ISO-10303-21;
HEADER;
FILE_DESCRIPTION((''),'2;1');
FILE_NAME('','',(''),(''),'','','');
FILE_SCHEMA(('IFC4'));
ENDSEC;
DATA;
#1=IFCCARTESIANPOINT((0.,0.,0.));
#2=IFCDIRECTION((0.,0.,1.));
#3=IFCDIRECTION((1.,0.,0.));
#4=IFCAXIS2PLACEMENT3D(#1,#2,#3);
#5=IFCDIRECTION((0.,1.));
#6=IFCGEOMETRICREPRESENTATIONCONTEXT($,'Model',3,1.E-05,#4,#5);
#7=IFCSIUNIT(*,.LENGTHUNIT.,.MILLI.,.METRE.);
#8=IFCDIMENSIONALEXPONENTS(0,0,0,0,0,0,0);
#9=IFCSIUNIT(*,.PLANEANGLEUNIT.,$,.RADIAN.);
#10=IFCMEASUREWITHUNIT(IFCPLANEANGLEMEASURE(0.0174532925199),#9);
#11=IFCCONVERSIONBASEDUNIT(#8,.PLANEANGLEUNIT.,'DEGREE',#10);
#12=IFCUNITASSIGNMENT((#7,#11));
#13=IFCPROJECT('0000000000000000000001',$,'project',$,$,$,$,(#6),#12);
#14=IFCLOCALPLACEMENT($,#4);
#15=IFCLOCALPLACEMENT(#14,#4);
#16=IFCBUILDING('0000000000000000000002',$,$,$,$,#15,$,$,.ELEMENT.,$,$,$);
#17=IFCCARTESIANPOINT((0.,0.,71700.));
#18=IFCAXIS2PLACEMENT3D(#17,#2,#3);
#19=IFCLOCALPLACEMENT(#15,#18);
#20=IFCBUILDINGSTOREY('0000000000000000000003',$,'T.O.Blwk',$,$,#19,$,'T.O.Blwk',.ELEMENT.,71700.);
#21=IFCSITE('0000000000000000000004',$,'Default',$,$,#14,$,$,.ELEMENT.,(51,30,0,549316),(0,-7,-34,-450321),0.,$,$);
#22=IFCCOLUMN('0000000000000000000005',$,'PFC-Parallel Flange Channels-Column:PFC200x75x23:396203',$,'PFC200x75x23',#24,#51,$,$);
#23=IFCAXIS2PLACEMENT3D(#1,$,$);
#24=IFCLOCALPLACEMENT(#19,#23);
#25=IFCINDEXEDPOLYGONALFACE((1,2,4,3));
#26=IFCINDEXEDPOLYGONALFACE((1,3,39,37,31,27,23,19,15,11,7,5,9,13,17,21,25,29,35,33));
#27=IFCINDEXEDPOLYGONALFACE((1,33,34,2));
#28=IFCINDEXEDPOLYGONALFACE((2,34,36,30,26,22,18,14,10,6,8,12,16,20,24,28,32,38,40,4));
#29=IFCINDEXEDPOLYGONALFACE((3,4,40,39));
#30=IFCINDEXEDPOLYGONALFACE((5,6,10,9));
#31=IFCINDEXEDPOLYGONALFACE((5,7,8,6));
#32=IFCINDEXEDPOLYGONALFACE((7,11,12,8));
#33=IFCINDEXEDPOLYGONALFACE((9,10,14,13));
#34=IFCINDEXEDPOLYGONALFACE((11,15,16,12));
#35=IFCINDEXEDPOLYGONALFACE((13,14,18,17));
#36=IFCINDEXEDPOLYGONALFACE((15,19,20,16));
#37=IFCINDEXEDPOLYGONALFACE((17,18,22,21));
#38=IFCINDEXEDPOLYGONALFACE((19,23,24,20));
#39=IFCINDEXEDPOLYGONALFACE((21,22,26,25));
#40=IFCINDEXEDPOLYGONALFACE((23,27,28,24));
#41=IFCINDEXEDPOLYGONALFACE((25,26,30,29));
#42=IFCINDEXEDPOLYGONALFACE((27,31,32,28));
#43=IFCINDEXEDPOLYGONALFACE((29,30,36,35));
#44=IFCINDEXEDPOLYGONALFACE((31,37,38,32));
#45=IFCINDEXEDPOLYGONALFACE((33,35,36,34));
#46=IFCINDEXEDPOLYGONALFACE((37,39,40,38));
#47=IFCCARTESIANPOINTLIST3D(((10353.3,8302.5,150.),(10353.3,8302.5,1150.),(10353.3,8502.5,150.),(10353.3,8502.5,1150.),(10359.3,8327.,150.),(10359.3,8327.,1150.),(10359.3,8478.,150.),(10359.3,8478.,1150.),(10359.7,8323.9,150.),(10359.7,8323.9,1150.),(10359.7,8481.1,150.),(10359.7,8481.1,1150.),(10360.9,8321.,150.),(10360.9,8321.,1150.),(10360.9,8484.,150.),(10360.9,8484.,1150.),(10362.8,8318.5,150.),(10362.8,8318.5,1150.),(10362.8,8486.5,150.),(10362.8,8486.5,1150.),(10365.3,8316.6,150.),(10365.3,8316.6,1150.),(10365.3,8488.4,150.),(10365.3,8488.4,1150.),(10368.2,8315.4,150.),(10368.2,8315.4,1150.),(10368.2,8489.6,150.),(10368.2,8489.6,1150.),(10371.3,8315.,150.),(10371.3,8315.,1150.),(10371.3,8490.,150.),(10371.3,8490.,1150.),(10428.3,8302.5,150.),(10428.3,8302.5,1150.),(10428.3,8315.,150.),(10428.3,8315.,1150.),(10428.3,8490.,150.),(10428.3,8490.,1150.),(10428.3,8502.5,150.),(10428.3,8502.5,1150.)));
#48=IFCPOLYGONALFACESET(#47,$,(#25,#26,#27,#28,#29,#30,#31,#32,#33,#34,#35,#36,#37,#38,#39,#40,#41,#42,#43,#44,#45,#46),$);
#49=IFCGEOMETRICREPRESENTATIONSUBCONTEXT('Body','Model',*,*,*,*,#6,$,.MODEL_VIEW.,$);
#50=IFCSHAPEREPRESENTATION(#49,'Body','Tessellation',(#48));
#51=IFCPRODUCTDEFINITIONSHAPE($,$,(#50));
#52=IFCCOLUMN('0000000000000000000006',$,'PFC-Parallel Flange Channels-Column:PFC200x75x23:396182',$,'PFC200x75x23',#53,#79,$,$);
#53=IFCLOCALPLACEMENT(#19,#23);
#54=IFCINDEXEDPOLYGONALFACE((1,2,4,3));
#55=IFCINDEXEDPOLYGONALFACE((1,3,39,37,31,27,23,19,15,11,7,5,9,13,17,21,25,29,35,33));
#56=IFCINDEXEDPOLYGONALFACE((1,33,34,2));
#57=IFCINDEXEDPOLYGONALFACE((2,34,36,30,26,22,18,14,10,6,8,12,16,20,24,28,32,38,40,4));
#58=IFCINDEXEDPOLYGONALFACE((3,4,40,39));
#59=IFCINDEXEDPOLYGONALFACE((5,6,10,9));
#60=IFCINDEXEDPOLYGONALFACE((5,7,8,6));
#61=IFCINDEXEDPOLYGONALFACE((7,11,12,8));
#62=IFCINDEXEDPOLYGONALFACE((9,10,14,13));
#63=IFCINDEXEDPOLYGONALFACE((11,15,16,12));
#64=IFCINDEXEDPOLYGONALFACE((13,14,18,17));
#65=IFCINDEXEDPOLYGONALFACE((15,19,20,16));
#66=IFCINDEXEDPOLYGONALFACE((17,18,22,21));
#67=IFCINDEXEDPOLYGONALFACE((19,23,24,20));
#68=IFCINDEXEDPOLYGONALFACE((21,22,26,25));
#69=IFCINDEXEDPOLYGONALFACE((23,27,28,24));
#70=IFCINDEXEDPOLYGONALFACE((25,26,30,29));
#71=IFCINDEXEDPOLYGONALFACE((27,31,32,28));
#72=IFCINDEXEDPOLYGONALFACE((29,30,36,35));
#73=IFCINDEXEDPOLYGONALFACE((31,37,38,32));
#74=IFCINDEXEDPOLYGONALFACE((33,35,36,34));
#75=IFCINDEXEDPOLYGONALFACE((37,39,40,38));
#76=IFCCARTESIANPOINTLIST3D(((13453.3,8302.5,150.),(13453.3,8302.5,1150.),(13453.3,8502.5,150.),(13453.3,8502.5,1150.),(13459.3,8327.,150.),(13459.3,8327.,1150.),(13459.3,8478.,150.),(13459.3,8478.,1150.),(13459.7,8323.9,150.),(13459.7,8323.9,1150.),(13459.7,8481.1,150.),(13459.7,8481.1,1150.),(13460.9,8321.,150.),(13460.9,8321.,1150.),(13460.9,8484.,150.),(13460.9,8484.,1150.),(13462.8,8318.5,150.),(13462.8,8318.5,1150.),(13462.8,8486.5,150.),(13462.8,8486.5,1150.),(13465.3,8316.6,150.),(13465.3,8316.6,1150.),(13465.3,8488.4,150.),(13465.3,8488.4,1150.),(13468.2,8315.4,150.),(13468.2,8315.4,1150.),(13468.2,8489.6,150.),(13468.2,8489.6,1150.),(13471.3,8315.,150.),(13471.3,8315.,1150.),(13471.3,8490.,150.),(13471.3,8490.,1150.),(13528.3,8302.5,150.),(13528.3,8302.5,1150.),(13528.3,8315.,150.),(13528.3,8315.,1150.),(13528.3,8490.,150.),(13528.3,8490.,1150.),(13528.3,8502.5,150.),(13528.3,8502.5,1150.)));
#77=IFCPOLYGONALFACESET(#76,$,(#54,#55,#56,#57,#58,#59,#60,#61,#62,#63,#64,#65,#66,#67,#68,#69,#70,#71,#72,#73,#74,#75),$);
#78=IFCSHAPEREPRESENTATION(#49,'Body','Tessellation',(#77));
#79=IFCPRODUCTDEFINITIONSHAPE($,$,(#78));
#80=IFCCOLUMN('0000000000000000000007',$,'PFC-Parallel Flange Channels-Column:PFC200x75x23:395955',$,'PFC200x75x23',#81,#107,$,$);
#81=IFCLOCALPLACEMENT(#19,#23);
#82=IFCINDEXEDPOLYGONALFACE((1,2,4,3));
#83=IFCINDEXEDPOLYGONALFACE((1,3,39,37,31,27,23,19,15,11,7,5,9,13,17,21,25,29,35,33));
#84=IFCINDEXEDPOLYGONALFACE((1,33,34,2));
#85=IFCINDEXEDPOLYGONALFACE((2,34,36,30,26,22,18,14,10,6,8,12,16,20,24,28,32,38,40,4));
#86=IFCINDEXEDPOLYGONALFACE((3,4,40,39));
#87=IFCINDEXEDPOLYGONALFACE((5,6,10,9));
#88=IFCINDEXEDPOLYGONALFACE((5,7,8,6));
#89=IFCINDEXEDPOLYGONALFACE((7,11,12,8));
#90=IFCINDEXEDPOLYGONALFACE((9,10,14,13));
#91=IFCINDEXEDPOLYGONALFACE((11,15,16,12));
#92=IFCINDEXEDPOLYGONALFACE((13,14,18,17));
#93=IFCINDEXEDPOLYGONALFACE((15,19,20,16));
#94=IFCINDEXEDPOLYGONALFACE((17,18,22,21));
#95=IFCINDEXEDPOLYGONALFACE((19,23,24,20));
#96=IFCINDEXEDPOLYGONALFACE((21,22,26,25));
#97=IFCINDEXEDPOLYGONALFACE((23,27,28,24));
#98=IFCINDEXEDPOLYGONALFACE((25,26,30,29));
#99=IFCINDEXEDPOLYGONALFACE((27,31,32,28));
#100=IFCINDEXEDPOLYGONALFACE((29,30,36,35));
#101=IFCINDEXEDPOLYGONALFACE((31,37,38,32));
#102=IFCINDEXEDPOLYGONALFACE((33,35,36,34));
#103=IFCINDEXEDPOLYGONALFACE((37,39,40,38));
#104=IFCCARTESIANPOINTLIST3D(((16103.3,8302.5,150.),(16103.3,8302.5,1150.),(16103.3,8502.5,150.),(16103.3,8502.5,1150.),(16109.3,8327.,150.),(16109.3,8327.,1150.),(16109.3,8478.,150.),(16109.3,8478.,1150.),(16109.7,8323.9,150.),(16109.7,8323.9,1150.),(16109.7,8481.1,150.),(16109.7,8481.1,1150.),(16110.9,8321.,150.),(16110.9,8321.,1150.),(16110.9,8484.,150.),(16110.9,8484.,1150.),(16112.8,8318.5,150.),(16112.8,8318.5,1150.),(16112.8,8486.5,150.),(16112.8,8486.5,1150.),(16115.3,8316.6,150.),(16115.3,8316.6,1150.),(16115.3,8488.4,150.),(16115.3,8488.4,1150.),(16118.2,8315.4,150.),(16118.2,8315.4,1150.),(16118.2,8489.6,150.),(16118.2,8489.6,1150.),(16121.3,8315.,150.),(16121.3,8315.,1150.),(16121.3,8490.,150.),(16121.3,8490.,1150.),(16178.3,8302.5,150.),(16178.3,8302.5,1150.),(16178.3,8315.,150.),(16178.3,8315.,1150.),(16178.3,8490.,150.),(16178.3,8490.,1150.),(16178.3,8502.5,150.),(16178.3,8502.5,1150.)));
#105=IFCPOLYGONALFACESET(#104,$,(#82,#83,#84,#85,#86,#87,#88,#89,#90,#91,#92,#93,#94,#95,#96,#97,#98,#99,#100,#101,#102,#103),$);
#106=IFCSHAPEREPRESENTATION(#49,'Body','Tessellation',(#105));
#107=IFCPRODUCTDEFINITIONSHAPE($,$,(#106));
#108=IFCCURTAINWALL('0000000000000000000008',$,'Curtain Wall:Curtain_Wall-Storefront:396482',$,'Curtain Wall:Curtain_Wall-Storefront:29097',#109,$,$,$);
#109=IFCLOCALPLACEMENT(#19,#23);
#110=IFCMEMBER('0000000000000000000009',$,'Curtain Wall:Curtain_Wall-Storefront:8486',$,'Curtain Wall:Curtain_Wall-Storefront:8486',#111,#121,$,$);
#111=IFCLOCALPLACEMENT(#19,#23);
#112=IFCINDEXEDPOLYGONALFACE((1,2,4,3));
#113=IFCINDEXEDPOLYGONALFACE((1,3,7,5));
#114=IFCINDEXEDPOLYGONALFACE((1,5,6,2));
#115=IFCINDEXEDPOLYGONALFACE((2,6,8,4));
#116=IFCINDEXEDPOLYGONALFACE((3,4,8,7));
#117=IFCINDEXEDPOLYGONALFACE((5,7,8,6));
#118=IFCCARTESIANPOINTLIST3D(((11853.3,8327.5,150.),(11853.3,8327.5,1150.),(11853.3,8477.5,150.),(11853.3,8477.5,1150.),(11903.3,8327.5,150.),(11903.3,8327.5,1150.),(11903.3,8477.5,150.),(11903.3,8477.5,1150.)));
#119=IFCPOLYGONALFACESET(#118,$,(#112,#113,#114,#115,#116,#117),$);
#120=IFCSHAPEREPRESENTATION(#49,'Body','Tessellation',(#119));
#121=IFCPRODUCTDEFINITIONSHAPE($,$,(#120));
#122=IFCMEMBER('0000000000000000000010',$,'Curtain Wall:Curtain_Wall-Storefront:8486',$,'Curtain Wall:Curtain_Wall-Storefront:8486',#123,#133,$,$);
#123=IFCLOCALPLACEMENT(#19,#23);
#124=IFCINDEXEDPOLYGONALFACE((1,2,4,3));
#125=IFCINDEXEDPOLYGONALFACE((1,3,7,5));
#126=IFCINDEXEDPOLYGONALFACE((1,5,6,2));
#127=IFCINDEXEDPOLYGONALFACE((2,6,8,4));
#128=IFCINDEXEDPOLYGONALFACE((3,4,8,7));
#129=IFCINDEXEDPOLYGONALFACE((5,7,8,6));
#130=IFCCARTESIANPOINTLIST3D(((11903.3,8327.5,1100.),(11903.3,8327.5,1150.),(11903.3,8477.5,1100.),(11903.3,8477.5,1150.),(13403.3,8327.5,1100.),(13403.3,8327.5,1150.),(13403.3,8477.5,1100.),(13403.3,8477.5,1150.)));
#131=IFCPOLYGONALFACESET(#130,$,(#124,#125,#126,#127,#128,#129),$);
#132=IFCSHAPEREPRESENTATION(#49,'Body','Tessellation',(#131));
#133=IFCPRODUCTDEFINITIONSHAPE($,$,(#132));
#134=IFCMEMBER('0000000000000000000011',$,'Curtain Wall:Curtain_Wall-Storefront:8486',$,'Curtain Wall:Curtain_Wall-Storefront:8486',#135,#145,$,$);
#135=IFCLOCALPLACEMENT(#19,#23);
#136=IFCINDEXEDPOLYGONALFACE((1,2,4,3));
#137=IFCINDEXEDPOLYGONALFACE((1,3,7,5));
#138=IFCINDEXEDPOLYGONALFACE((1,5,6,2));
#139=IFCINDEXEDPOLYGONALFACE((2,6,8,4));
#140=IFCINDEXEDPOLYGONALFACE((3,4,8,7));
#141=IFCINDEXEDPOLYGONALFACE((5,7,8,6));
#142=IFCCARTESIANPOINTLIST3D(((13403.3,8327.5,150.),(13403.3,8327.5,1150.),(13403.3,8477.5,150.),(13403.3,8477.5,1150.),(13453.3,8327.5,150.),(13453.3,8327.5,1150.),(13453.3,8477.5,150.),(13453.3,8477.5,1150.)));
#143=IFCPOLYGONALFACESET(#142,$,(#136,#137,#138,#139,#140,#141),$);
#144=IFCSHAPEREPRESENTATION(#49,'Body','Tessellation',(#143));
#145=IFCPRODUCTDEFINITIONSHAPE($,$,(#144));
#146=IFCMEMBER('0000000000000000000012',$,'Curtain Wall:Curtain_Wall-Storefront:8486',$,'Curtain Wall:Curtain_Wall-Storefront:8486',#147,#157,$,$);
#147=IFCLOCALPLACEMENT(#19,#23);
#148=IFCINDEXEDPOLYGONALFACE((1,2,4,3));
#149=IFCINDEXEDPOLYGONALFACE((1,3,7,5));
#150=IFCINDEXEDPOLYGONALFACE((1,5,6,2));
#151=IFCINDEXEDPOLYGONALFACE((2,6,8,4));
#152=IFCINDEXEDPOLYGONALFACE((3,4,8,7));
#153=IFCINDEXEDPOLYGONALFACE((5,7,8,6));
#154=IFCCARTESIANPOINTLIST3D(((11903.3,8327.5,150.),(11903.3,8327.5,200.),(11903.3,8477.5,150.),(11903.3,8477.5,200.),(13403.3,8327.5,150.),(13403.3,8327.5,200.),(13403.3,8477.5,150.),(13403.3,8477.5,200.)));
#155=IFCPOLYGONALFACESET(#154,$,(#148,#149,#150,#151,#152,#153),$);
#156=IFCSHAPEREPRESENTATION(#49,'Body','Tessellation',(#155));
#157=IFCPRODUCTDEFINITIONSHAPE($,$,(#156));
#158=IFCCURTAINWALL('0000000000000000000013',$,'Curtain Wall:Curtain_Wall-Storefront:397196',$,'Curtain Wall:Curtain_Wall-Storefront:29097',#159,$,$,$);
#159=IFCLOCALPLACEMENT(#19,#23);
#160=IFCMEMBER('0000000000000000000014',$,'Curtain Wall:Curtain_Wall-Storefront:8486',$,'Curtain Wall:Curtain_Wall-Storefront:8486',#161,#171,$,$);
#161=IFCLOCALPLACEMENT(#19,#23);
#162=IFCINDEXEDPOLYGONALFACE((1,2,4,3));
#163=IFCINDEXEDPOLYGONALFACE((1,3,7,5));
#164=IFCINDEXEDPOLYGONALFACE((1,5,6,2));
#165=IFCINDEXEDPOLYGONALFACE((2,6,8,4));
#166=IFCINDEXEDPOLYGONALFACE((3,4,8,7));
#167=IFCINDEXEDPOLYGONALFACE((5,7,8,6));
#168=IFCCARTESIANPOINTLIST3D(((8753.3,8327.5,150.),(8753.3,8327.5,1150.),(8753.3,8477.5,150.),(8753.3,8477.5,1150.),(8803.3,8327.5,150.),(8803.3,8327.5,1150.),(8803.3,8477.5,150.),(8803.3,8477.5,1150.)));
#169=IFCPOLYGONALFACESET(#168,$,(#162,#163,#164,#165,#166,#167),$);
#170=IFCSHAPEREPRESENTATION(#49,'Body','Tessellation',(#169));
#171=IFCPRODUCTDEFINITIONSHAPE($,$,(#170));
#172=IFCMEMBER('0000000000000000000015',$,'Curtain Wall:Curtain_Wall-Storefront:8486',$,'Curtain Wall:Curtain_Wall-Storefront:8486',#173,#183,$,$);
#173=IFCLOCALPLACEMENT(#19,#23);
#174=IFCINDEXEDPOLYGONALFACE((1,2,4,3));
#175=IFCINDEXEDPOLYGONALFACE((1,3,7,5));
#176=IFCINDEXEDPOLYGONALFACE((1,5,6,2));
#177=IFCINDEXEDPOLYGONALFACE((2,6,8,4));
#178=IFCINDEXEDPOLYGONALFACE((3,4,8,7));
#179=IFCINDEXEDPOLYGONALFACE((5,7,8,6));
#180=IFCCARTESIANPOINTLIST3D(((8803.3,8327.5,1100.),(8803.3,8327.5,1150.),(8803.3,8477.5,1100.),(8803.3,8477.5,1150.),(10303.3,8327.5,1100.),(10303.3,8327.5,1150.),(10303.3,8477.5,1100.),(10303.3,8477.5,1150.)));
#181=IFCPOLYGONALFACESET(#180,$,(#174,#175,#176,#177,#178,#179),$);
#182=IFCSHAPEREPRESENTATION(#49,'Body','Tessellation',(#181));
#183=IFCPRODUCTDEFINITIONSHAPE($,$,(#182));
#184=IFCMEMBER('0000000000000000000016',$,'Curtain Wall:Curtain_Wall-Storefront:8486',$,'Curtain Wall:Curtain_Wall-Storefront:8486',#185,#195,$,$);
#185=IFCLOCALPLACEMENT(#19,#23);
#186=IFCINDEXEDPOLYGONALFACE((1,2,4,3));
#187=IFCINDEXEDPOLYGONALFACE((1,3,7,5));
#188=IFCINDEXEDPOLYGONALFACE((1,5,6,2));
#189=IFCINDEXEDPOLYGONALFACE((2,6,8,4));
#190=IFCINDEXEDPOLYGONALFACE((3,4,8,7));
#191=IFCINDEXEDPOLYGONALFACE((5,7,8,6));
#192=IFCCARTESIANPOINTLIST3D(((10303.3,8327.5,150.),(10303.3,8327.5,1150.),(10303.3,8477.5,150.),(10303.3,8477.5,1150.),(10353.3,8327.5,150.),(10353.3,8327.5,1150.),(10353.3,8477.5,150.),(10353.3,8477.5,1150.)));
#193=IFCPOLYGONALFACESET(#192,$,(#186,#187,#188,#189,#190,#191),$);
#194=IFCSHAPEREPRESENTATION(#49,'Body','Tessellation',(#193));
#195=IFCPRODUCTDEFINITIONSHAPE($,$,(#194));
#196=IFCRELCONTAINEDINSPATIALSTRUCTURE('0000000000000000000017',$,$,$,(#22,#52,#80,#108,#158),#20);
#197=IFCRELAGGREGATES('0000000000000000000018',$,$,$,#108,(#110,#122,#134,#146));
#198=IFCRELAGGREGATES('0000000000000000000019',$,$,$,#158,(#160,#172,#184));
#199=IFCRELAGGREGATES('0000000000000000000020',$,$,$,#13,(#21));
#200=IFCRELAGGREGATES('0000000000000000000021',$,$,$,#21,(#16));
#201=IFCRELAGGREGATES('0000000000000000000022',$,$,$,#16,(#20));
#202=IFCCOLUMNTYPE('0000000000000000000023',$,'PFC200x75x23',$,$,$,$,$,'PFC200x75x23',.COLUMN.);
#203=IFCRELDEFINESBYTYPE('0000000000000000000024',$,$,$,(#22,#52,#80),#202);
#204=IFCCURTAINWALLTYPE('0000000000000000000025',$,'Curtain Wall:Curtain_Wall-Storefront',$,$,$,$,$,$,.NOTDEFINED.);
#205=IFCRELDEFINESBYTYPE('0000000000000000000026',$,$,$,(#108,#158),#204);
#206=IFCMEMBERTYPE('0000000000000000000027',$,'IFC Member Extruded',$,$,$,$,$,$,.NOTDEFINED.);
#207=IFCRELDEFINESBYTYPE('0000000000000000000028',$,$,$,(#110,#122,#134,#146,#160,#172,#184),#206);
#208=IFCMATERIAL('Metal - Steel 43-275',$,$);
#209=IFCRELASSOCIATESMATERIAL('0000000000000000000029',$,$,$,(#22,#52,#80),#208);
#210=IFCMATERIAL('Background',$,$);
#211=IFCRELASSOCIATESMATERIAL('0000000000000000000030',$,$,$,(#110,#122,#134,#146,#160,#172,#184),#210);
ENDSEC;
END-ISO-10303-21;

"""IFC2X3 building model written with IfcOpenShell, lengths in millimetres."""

from ifc_helpers import new_model, entity, si_unit, converted_unit, point, direction, frame, frame_2d, origin_with_axes, origin_2d_with_axis, place, context, subcontext, project, spatial, polyline, circle_curve, parameter, trimmed, segment, composite_curve, rectangle, outline, extrude, material, type_object, element, aggregate, save


model = new_model("IFC2X3")

# Units and contexts
model_context = context("Model", 3, precision=1e-05, world=origin_with_axes(), true_north=direction((0.0, 1.0)))
body_context = subcontext(model_context, "Body", "Model", "MODEL_VIEW")
ifc_project = project(units=[si_unit("LENGTHUNIT", "METRE", prefix="MILLI"), converted_unit("PLANEANGLEUNIT", "DEGREE", entity("IfcPlaneAngleMeasure", 0.0174532925199), si_unit("PLANEANGLEUNIT", "RADIAN"), dimensions=[0, 0, 0, 0, 0, 0, 0])], contexts=[model_context])

# Site, building, storey
site_placement = place(None, origin_with_axes())
site = spatial("IfcSite", under=ifc_project, at=site_placement, Name="Default", CompositionType="ELEMENT", RefLatitude=(51, 30, 0, 549316), RefLongitude=(0, -7, -34, -450321), RefElevation=0.0)
building_placement = place(site_placement, origin_with_axes())
building = spatial("IfcBuilding", under=site, at=building_placement, CompositionType="ELEMENT")
storey_placement = place(building_placement, frame((0.0, 0.0, 71700.0), z_axis=(0.0, 0.0, 1.0), x_axis=(1.0, 0.0, 0.0)))
storey = spatial("IfcBuildingStorey", under=building, at=storey_placement, Name="T.O.Blwk", LongName="T.O.Blwk", CompositionType="ELEMENT", Elevation=71700.0)

# Columns
ifc_material_1 = material(Name="Metal - Steel 43-275")
column_type_1 = type_object("IfcColumnType", Name="PFC200x75x23", ElementType="PFC200x75x23", PredefinedType="COLUMN")
for number, where, z_axis, x_axis, name in (
    (1, (10388.1, 8402.5, 150.0), (0.0, 0.0, 1.0), (0.0, -1.0, 0.0), "PFC-Parallel Flange Channels-Column:PFC200x75x23:396203"),
    (2, (13488.1, 8402.5, 150.0), (0.0, 0.0, 1.0), (0.0, -1.0, 0.0), "PFC-Parallel Flange Channels-Column:PFC200x75x23:396182"),
    (3, (16138.1, 8402.5, 150.0), (0.0, 0.0, 1.0), (0.0, -1.0, 0.0), "PFC-Parallel Flange Channels-Column:PFC200x75x23:395955"),
):
    element("IfcColumn", number, at=place(storey_placement, frame(where, z_axis=z_axis, x_axis=x_axis)), inside=storey, type_object=column_type_1, material=ifc_material_1, Name=name, ObjectType="PFC200x75x23", context=body_context, shape_type="SweptSolid", body=[
        extrude(outline(composite_curve([segment(polyline([(-100.0, -34.8), (100.0, -34.8), (100.0, 40.2), (87.5, 40.2), (87.5, -16.8)]), True, "CONTINUOUS"), segment(trimmed(circle_curve(frame_2d((75.5, -16.8), x_axis=(0.0, -1.0)), 12.0), [point((87.5, -16.8)), parameter(90.0)], [point((75.5, -28.8)), parameter(0.0)], False, "CARTESIAN"), True, "CONTINUOUS"), segment(polyline([(75.5, -28.8), (-75.5, -28.8)]), True, "CONTINUOUS"), segment(trimmed(circle_curve(frame_2d((-75.5, -16.8), x_axis=(-1.0, 0.0)), 12.0), [point((-75.5, -28.8)), parameter(90.0)], [point((-87.5, -16.8)), parameter(0.0)], False, "CARTESIAN"), True, "CONTINUOUS"), segment(polyline([(-87.5, -16.8), (-87.5, 40.2), (-100.0, 40.2), (-100.0, -34.8)]), True, "CONTINUOUS")], self_intersect=False)), origin_with_axes(), (0.0, 0.0, 1.0), 1000.0),
    ])

# Curtain walls, members
curtain_wall_type = type_object("IfcCurtainWallType", Name="Curtain Wall:Curtain_Wall-Storefront", PredefinedType="NOTDEFINED")
curtain_wall_1_placement = place(storey_placement, frame((0.0, 0.0, -71700.0), z_axis=(0.0, 0.0, 1.0), x_axis=(1.0, 0.0, 0.0)))
curtain_wall_1 = element("IfcCurtainWall", 4, at=curtain_wall_1_placement, inside=storey, type_object=curtain_wall_type, Name="Curtain Wall:Curtain_Wall-Storefront:396482", ObjectType="Curtain Wall:Curtain_Wall-Storefront:29097")
ifc_material_2 = material(Name="Background")
member_type = type_object("IfcMemberType", Name="IFC Member Extruded", PredefinedType="NOTDEFINED")
member_1_placement = place(curtain_wall_1_placement, frame((0.0, 0.0, 71700.0), z_axis=(0.0, 0.0, 1.0), x_axis=(1.0, 0.0, 0.0)))
member_1 = element("IfcMember", 5, at=member_1_placement, type_object=member_type, material=ifc_material_2, Name="Curtain Wall:Curtain_Wall-Storefront:8486", ObjectType="Curtain Wall:Curtain_Wall-Storefront:8486", context=body_context, shape_type="SweptSolid", body=[
    extrude(rectangle(XDim=50.0, YDim=150.0, at=origin_2d_with_axis()), frame((11878.3, 8402.5, 1150.0), z_axis=(0.0, 0.0, -1.0), x_axis=(-1.0, 0.0, 0.0)), (0.0, 0.0, 1.0), 1000.0),
])
member_2_placement = place(curtain_wall_1_placement, frame((0.0, 0.0, 71700.0), z_axis=(0.0, 0.0, 1.0), x_axis=(1.0, 0.0, 0.0)))
member_2 = element("IfcMember", 6, at=member_2_placement, type_object=member_type, material=ifc_material_2, Name="Curtain Wall:Curtain_Wall-Storefront:8486", ObjectType="Curtain Wall:Curtain_Wall-Storefront:8486", context=body_context, shape_type="SweptSolid", body=[
    extrude(rectangle(XDim=50.0, YDim=150.0, at=origin_2d_with_axis()), frame((13403.3, 8402.5, 1125.0), z_axis=(-1.0, 0.0, 0.0), x_axis=(0.0, 0.0, -1.0)), (0.0, 0.0, 1.0), 1500.0),
])
member_3_placement = place(curtain_wall_1_placement, frame((0.0, 0.0, 71700.0), z_axis=(0.0, 0.0, 1.0), x_axis=(1.0, 0.0, 0.0)))
member_3 = element("IfcMember", 7, at=member_3_placement, type_object=member_type, material=ifc_material_2, Name="Curtain Wall:Curtain_Wall-Storefront:8486", ObjectType="Curtain Wall:Curtain_Wall-Storefront:8486", context=body_context, shape_type="SweptSolid", body=[
    extrude(rectangle(XDim=50.0, YDim=150.0, at=origin_2d_with_axis()), frame((13428.3, 8402.5, 150.0), z_axis=(0.0, 0.0, 1.0), x_axis=(-1.0, 0.0, 0.0)), (0.0, 0.0, 1.0), 1000.0),
])
member_4_placement = place(curtain_wall_1_placement, frame((0.0, 0.0, 71700.0), z_axis=(0.0, 0.0, 1.0), x_axis=(1.0, 0.0, 0.0)))
member_4 = element("IfcMember", 8, at=member_4_placement, type_object=member_type, material=ifc_material_2, Name="Curtain Wall:Curtain_Wall-Storefront:8486", ObjectType="Curtain Wall:Curtain_Wall-Storefront:8486", context=body_context, shape_type="SweptSolid", body=[
    extrude(rectangle(XDim=50.0, YDim=150.0, at=origin_2d_with_axis()), frame((11903.3, 8402.5, 175.0), z_axis=(1.0, 0.0, 0.0), x_axis=(0.0, 0.0, -1.0)), (0.0, 0.0, 1.0), 1500.0),
])
curtain_wall_2_placement = place(storey_placement, frame((0.0, 0.0, -71700.0), z_axis=(0.0, 0.0, 1.0), x_axis=(1.0, 0.0, 0.0)))
curtain_wall_2 = element("IfcCurtainWall", 9, at=curtain_wall_2_placement, inside=storey, type_object=curtain_wall_type, Name="Curtain Wall:Curtain_Wall-Storefront:397196", ObjectType="Curtain Wall:Curtain_Wall-Storefront:29097")
member_5_placement = place(curtain_wall_2_placement, frame((0.0, 0.0, 71700.0), z_axis=(0.0, 0.0, 1.0), x_axis=(1.0, 0.0, 0.0)))
member_5 = element("IfcMember", 10, at=member_5_placement, type_object=member_type, material=ifc_material_2, Name="Curtain Wall:Curtain_Wall-Storefront:8486", ObjectType="Curtain Wall:Curtain_Wall-Storefront:8486", context=body_context, shape_type="SweptSolid", body=[
    extrude(rectangle(XDim=50.0, YDim=150.0, at=origin_2d_with_axis()), frame((8778.3, 8402.5, 1150.0), z_axis=(0.0, 0.0, -1.0), x_axis=(-1.0, 0.0, 0.0)), (0.0, 0.0, 1.0), 1000.0),
])
member_6_placement = place(curtain_wall_2_placement, frame((0.0, 0.0, 71700.0), z_axis=(0.0, 0.0, 1.0), x_axis=(1.0, 0.0, 0.0)))
member_6 = element("IfcMember", 11, at=member_6_placement, type_object=member_type, material=ifc_material_2, Name="Curtain Wall:Curtain_Wall-Storefront:8486", ObjectType="Curtain Wall:Curtain_Wall-Storefront:8486", context=body_context, shape_type="SweptSolid", body=[
    extrude(rectangle(XDim=50.0, YDim=150.0, at=origin_2d_with_axis()), frame((10303.3, 8402.5, 1125.0), z_axis=(-1.0, 0.0, 0.0), x_axis=(0.0, 0.0, -1.0)), (0.0, 0.0, 1.0), 1500.0),
])
member_7_placement = place(curtain_wall_2_placement, frame((0.0, 0.0, 71700.0), z_axis=(0.0, 0.0, 1.0), x_axis=(1.0, 0.0, 0.0)))
member_7 = element("IfcMember", 12, at=member_7_placement, type_object=member_type, material=ifc_material_2, Name="Curtain Wall:Curtain_Wall-Storefront:8486", ObjectType="Curtain Wall:Curtain_Wall-Storefront:8486", context=body_context, shape_type="SweptSolid", body=[
    extrude(rectangle(XDim=50.0, YDim=150.0, at=origin_2d_with_axis()), frame((10328.3, 8402.5, 150.0), z_axis=(0.0, 0.0, 1.0), x_axis=(-1.0, 0.0, 0.0)), (0.0, 0.0, 1.0), 1000.0),
])

aggregate(curtain_wall_1, [member_1, member_2, member_3, member_4])
aggregate(curtain_wall_2, [member_5, member_6, member_7])

save(model, "model.ifc")
